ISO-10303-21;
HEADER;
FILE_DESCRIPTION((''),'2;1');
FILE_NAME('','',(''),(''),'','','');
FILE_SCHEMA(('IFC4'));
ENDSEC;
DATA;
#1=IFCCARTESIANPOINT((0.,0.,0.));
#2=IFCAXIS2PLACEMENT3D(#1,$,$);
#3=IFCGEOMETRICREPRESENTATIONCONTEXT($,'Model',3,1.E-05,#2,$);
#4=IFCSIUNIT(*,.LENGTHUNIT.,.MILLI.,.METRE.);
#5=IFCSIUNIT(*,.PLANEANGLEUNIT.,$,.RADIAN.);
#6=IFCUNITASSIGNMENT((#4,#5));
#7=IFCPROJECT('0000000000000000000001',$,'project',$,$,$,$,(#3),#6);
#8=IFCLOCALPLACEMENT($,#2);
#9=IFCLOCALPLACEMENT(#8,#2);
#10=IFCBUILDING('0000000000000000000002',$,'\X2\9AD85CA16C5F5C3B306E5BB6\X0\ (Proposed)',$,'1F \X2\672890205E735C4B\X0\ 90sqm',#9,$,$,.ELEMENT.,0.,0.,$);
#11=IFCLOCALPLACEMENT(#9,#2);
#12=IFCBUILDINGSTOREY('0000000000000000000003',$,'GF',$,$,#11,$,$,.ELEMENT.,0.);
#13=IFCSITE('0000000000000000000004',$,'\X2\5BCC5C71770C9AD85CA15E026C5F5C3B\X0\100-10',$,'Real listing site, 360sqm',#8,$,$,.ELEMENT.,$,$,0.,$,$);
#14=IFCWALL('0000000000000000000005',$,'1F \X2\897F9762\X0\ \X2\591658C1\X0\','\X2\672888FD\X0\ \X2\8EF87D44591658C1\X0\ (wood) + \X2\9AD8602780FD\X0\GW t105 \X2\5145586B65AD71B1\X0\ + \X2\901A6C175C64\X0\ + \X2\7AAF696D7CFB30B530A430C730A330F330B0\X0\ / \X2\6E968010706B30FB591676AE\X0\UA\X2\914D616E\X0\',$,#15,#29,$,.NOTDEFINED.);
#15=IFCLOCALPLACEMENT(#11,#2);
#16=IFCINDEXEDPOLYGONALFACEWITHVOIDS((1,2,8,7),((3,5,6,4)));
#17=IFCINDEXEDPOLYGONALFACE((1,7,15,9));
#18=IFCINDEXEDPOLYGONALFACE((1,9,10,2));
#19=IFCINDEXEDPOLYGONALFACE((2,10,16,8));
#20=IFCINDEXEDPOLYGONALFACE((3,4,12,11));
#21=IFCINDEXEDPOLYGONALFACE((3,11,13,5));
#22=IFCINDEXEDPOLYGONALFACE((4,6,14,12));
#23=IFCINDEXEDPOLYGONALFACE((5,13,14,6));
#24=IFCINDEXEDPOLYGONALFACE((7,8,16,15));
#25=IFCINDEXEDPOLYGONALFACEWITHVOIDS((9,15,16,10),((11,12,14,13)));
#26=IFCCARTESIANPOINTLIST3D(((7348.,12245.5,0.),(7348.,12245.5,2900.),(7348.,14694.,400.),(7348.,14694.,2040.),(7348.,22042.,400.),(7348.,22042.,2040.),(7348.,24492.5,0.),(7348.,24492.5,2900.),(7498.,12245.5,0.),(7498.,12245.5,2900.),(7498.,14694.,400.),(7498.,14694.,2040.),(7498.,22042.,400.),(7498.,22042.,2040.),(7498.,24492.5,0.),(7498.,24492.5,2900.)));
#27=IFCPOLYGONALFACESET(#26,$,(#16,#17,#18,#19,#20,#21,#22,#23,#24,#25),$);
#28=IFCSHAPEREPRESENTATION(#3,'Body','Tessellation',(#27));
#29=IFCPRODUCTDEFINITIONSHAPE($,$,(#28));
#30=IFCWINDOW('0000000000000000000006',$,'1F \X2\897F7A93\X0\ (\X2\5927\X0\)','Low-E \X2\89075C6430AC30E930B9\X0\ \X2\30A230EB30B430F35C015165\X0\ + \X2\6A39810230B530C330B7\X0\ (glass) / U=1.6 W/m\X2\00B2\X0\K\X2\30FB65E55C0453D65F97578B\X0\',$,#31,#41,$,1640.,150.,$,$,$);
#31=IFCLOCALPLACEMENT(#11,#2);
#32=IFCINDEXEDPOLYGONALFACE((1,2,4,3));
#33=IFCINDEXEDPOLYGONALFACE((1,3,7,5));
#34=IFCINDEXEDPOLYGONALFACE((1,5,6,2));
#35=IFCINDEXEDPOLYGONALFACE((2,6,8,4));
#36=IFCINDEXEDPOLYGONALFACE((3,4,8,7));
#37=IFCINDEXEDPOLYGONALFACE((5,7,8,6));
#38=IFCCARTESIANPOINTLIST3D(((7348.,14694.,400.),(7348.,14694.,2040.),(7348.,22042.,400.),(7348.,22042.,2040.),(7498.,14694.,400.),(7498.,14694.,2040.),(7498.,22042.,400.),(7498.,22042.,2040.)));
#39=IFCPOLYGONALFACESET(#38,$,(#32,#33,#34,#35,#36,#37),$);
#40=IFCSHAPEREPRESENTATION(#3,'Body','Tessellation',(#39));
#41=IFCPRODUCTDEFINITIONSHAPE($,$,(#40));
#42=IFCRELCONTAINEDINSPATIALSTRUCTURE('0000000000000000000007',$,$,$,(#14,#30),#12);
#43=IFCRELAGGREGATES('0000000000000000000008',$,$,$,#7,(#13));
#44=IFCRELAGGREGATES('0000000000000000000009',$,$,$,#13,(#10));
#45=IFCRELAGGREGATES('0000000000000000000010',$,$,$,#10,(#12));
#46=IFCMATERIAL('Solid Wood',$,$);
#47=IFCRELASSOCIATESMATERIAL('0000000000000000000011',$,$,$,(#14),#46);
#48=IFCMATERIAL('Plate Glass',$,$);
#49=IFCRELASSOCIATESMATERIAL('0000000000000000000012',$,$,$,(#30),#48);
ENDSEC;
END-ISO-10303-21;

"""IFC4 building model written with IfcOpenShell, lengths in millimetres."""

from ifc_helpers import new_model, si_unit, frame, frame_2d, origin, place, context, project, spatial, rectangle, extrude, material, element, fill, save


model = new_model("IFC4")

# Units and contexts
model_context = context("Model", 3, precision=1e-05, world=origin())
ifc_project = project(units=[si_unit("LENGTHUNIT", "METRE", prefix="MILLI"), si_unit("PLANEANGLEUNIT", "RADIAN")], contexts=[model_context])

# Site, building, storey
site_placement = place(None, origin())
site = spatial("IfcSite", under=ifc_project, at=site_placement, Name="富山県高岡市江尻100-10", ObjectType="Real listing site, 360sqm", CompositionType="ELEMENT", RefElevation=0.0)
building_placement = place(site_placement, origin())
building = spatial("IfcBuilding", under=site, at=building_placement, Name="高岡江尻の家 (Proposed)", ObjectType="1F 木造平屋 90sqm", CompositionType="ELEMENT", ElevationOfRefHeight=0.0, ElevationOfTerrain=0.0)
storey_placement = place(building_placement, origin())
storey = spatial("IfcBuildingStorey", under=building, at=storey_placement, Name="GF", CompositionType="ELEMENT", Elevation=0.0)

# Shared definitions
ifc_material_1 = material(Name="Solid Wood")

# Shared definitions
ifc_material_2 = material(Name="Plate Glass")

# Wall, opening, window
wall_1_placement = place(storey_placement, frame((3674.0, 6123.0, 0.0)))
wall_1 = element("IfcWall", 1, at=wall_1_placement, inside=storey, material=ifc_material_1, Name="1F 西面 外壁", Description="木製 軸組外壁 (wood) + 高性能GW t105 充填断熱 + 通気層 + 窯業系サイディング / 準耐火・外皮UA配慮", PredefinedType="NOTDEFINED", context=model_context, shape_type="SweptSolid", body=[
    extrude(rectangle(XDim=150.0, YDim=12247.0, at=frame_2d((75.0, 6123.0))), frame((3674.0, 6123.0, 0.0)), (0.0, 0.0, 1.0), 2900.0),
])
opening_1_placement = place(storey_placement, frame((3674.0, 7347.0, 200.0)))
opening_1 = element("IfcOpeningElement", 2, at=opening_1_placement, cuts=wall_1, PredefinedType="NOTDEFINED", context=model_context, shape_type="SweptSolid", body=[
    extrude(rectangle(XDim=150.0, YDim=7348.0, at=frame_2d((75.0, 3674.0))), frame((3674.0, 7347.0, 200.0)), (0.0, 0.0, 1.0), 1640.0),
])
window_1_placement = place(storey_placement, frame((3674.0, 7347.0, 200.0)))
window_1 = element("IfcWindow", 3, at=window_1_placement, inside=storey, material=ifc_material_2, Name="1F 西窓 (大)", Description="Low-E 複層ガラス アルゴン封入 + 樹脂サッシ (glass) / U=1.6 W/m²K・日射取得型", OverallHeight=1640.0, OverallWidth=150.0, context=model_context, shape_type="SweptSolid", body=[
    extrude(rectangle(XDim=150.0, YDim=7348.0, at=frame_2d((75.0, 3674.0))), frame((3674.0, 7347.0, 200.0)), (0.0, 0.0, 1.0), 1640.0),
])
fill(opening_1, window_1)

save(model, "model.ifc")
